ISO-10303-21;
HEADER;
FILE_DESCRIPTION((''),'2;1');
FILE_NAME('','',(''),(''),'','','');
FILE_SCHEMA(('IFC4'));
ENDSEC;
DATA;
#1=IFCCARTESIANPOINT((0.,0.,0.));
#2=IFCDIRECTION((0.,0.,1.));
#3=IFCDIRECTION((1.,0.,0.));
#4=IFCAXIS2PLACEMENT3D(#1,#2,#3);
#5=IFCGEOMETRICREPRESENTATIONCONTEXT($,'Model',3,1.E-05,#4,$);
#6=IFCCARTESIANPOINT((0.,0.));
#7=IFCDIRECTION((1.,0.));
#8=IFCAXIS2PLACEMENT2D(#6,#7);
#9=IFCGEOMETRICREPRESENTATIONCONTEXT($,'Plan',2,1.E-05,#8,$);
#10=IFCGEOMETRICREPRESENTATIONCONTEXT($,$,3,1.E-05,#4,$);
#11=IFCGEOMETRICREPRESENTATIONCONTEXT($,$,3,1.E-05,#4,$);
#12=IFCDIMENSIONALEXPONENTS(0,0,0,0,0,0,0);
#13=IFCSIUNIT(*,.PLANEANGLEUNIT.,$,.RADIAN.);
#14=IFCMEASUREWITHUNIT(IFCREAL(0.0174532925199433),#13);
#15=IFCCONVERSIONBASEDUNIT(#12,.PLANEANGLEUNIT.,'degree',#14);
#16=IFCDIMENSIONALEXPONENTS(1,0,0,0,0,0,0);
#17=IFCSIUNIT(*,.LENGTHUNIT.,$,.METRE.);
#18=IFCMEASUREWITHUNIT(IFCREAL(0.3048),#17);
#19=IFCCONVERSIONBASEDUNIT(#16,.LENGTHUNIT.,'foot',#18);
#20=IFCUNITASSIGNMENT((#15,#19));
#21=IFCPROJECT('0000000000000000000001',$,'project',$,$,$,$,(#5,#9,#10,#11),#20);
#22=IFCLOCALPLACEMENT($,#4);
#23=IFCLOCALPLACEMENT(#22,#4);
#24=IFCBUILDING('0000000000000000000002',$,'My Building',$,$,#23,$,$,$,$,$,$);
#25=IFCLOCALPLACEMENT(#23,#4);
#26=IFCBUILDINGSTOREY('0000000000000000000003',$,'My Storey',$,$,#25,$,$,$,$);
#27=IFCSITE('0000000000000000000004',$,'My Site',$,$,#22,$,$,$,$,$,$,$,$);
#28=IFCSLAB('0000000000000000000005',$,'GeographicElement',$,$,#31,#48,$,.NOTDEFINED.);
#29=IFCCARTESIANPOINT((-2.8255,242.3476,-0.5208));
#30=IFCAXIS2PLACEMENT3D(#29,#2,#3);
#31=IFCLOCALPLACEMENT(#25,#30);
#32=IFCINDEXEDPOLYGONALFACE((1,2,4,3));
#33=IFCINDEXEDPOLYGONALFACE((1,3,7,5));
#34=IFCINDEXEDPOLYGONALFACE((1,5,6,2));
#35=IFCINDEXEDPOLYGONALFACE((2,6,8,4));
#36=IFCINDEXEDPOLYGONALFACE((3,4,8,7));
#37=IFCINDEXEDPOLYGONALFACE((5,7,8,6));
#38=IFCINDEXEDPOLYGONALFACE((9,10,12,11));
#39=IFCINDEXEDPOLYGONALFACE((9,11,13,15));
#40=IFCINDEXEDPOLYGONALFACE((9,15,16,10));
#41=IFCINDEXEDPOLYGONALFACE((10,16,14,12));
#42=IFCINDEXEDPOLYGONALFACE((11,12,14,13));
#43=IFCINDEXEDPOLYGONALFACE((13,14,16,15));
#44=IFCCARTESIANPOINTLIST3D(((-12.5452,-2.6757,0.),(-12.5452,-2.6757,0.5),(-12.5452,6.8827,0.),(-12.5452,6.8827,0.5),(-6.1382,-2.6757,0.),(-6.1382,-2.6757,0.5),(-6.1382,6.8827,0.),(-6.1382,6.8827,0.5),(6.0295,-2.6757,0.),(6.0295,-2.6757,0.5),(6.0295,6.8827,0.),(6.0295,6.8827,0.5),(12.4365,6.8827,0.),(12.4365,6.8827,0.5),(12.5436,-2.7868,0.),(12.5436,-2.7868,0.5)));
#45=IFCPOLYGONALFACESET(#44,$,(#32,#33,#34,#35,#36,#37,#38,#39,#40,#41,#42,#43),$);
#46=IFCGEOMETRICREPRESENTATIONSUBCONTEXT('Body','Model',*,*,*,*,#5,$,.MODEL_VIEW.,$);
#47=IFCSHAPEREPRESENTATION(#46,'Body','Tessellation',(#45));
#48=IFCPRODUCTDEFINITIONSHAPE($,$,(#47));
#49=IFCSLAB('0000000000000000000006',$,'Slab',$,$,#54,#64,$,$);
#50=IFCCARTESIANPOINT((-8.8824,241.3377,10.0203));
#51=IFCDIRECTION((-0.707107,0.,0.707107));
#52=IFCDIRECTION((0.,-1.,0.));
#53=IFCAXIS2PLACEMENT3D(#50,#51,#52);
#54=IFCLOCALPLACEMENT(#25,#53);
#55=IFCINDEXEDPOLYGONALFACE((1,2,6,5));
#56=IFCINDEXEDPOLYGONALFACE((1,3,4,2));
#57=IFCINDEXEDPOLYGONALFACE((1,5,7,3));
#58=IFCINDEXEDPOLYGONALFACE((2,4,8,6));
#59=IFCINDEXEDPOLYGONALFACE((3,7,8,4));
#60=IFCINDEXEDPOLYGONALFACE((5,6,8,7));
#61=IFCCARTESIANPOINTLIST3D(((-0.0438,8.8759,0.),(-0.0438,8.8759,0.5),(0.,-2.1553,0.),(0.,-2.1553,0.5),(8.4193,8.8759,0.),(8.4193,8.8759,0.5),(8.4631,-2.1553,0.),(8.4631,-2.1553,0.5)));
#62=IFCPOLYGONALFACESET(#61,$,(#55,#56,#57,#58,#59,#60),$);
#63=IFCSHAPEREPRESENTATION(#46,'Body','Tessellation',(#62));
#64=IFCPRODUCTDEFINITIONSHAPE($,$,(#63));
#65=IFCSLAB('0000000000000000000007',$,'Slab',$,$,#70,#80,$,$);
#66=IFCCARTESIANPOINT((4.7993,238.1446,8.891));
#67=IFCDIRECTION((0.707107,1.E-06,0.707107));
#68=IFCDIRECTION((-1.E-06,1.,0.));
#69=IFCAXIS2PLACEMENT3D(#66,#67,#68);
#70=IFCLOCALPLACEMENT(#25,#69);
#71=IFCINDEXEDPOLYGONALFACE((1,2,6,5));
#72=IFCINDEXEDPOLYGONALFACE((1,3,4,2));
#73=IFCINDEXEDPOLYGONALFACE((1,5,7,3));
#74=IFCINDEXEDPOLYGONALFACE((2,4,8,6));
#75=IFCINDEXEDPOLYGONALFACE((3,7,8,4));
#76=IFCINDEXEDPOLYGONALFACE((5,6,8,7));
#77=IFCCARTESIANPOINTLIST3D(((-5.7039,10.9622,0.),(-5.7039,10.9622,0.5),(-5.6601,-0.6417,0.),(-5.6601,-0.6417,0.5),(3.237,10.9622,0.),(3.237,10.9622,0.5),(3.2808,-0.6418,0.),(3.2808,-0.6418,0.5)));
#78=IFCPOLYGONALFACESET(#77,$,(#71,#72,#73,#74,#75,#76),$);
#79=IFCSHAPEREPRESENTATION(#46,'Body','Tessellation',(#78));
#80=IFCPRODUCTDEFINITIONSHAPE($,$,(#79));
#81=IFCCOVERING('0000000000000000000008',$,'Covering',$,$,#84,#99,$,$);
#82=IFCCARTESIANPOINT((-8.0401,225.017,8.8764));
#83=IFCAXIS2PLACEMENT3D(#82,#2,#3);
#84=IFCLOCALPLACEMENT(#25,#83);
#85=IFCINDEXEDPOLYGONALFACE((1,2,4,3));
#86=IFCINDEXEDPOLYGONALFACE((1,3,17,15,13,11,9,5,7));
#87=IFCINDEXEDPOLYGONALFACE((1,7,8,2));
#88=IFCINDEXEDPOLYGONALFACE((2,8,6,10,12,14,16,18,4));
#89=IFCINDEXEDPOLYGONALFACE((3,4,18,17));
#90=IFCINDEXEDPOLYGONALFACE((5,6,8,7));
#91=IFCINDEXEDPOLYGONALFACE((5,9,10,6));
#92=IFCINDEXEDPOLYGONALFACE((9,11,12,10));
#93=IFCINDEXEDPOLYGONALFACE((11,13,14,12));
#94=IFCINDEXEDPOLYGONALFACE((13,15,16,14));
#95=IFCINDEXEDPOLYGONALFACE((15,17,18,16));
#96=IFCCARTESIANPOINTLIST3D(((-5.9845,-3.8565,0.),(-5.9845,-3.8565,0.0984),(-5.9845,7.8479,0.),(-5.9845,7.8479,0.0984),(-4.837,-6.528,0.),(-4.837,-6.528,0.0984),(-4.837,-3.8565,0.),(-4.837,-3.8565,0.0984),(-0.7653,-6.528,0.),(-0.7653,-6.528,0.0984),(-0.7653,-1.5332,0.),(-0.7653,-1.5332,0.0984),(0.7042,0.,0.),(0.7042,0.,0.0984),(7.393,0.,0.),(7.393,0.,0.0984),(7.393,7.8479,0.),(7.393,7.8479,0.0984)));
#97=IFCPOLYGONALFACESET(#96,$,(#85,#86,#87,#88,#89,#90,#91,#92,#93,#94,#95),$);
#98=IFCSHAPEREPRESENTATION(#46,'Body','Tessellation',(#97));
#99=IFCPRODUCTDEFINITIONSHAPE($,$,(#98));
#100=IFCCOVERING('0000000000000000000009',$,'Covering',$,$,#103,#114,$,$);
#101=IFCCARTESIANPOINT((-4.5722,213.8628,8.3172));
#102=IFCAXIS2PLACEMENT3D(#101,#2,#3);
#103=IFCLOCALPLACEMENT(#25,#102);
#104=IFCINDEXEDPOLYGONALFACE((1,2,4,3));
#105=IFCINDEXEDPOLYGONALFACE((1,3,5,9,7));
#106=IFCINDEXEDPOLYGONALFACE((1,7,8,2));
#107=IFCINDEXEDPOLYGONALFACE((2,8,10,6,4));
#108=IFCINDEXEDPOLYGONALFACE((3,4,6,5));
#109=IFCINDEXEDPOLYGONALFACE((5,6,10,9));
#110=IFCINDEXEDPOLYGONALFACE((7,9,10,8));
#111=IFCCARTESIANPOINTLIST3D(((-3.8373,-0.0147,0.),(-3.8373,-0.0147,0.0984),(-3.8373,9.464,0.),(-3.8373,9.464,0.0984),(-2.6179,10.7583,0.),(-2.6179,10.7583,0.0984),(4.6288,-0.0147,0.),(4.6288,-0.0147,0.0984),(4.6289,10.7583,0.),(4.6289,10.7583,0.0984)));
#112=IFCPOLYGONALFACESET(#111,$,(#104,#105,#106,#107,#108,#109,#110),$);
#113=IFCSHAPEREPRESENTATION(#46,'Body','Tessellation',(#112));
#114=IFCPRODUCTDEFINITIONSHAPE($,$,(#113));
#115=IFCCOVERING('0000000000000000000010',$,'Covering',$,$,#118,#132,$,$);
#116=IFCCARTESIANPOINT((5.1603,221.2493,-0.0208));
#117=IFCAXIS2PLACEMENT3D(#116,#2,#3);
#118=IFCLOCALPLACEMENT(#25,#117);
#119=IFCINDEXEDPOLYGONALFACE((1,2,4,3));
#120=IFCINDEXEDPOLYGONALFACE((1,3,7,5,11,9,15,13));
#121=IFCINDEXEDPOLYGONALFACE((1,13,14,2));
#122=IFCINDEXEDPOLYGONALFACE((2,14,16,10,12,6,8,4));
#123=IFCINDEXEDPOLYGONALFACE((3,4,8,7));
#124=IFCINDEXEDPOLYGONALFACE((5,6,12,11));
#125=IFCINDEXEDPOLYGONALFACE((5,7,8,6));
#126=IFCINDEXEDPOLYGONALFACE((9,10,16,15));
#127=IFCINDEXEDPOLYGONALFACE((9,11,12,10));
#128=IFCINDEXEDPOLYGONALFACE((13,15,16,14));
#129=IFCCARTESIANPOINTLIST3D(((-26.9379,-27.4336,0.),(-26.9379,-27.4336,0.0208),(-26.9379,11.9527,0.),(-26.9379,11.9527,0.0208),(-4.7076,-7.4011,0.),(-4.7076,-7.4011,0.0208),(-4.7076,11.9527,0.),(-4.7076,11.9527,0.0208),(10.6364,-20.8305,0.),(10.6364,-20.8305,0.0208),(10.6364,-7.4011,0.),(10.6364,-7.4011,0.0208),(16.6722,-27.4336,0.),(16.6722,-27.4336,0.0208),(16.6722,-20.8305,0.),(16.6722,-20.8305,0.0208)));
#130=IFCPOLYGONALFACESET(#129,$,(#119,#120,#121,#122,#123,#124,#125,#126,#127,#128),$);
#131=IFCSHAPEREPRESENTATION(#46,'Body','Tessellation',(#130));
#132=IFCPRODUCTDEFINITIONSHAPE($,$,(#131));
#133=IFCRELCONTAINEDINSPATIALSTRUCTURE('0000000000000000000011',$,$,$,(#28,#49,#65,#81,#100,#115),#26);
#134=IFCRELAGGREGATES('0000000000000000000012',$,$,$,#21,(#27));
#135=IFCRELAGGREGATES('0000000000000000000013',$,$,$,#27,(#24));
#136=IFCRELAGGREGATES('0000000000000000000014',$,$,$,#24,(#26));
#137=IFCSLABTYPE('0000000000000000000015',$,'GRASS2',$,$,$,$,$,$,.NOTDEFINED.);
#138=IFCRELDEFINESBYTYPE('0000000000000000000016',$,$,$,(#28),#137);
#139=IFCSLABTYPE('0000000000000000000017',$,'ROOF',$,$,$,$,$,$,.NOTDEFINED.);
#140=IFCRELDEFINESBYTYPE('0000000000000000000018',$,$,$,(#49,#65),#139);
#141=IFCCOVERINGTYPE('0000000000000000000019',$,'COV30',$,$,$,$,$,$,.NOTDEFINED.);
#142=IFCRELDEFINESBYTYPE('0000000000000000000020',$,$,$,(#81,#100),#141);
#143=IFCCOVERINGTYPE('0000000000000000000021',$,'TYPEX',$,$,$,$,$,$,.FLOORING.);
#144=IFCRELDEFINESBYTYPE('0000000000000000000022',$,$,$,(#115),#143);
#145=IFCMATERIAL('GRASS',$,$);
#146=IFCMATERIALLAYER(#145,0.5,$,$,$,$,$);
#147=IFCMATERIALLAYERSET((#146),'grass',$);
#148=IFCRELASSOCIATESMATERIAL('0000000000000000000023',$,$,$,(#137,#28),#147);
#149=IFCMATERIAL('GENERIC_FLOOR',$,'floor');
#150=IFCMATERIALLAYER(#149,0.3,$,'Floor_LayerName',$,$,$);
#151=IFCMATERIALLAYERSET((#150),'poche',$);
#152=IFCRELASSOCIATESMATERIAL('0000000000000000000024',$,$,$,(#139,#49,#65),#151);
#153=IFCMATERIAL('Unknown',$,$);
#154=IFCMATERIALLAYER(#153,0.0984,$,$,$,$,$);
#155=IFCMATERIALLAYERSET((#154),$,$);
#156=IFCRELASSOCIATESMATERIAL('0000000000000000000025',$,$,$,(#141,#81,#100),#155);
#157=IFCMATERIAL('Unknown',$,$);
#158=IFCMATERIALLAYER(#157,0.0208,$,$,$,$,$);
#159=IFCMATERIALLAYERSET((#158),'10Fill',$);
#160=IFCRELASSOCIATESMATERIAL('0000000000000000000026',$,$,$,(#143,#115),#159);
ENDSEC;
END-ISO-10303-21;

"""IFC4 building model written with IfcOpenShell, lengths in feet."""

from ifc_helpers import new_model, entity, si_unit, converted_unit, frame, origin_with_axes, origin_2d_with_axis, place, context, subcontext, project, spatial, line, indexed_curve, outline, extrude, material, layer, layer_set, layer_usage, type_object, element, save


model = new_model("IFC4")

# Units and contexts
model_context = context("Model", 3, precision=1e-05, world=origin_with_axes())
plan_context = context("Plan", 2, precision=1e-05, world=origin_2d_with_axis())
context_of_model_1 = context(None, 3, precision=1e-05, world=origin_with_axes())
context_of_model_2 = context(None, 3, precision=1e-05, world=origin_with_axes())
body_context_1 = subcontext(model_context, "Body", "Model", "MODEL_VIEW")
ifc_project = project(units=[converted_unit("PLANEANGLEUNIT", "degree", entity("IfcReal", 0.0174532925199433), si_unit("PLANEANGLEUNIT", "RADIAN"), dimensions=[0, 0, 0, 0, 0, 0, 0]), converted_unit("LENGTHUNIT", "foot", entity("IfcReal", 0.3048), si_unit("LENGTHUNIT", "METRE"), dimensions=[1, 0, 0, 0, 0, 0, 0])], contexts=[model_context, plan_context, context_of_model_1, context_of_model_2])

# Site, building, storey
site_placement = place(None, origin_with_axes())
site = spatial("IfcSite", under=ifc_project, at=site_placement, Name="My Site")
building_placement = place(site_placement, origin_with_axes())
building = spatial("IfcBuilding", under=site, at=building_placement, Name="My Building")
storey_placement = place(building_placement, origin_with_axes())
storey = spatial("IfcBuildingStorey", under=building, at=storey_placement, Name="My Storey")

# Slabs
ifc_material_1 = material(Name="GRASS")
ifc_layer_1 = layer(ifc_material_1, 0.5)
ifc_layer_set_1 = layer_set([ifc_layer_1], Name="grass")
ifc_layer_usage_1 = layer_usage(ifc_layer_set_1, "AXIS3", "POSITIVE", 0.0)
slab_type_1 = type_object("IfcSlabType", Name="GRASS2", PredefinedType="NOTDEFINED", material=ifc_layer_set_1)
slab_1_placement = place(storey_placement, frame((-2.8255, 242.3476, -0.5208), z_axis=(0.0, 0.0, 1.0), x_axis=(1.0, 0.0, 0.0)))
element("IfcSlab", 1, at=slab_1_placement, inside=storey, type_object=slab_type_1, material=ifc_layer_usage_1, Name="GeographicElement", PredefinedType="NOTDEFINED", context=body_context_1, shape_type="SweptSolid", body=[
    extrude(outline(indexed_curve([(-12.5452, -2.6757), (-6.1382, -2.6757), (-6.1382, 6.8827), (-12.5452, 6.8827), (6.0295, -2.6757), (6.0295, 6.8827), (12.4365, 6.8827), (12.5436, -2.7868)], segments=[line(7, 6), line(6, 5), line(5, 8), line(8, 7)], self_intersect=False), holes=[indexed_curve([(-12.5452, -2.6757), (-6.1382, -2.6757), (-6.1382, 6.8827), (-12.5452, 6.8827), (6.0295, -2.6757), (6.0295, 6.8827), (12.4365, 6.8827), (12.5436, -2.7868)], segments=[line(3, 4), line(4, 1), line(1, 2), line(2, 3)], self_intersect=False)]), None, (0.0, 0.0, 1.0), 0.5),
])
ifc_material_2 = material(Name="GENERIC_FLOOR", Category="floor")
ifc_layer_2 = layer(ifc_material_2, 0.3, Name="Floor_LayerName")
ifc_layer_set_2 = layer_set([ifc_layer_2], Name="poche")
ifc_layer_usage_2 = layer_usage(ifc_layer_set_2, "AXIS3", "POSITIVE", 0.0)
slab_type_2 = type_object("IfcSlabType", Name="ROOF", PredefinedType="NOTDEFINED", material=ifc_layer_set_2)
slab_2_placement = place(storey_placement, frame((-8.8824, 241.3377, 10.0203), z_axis=(-0.707107, 0.0, 0.707107), x_axis=(0.0, -1.0, 0.0)))
element("IfcSlab", 2, at=slab_2_placement, inside=storey, type_object=slab_type_2, material=ifc_layer_usage_2, Name="Slab", context=body_context_1, shape_type="SweptSolid", body=[
    extrude(outline(indexed_curve([(0.0, -2.1553), (8.4631, -2.1553), (8.4193, 8.8759), (-0.0438, 8.8759)], segments=[line(3, 2), line(2, 1), line(1, 4), line(4, 3)], self_intersect=False)), None, (0.0, 0.0, 1.0), 0.5),
])
ifc_layer_usage_3 = layer_usage(ifc_layer_set_2, "AXIS3", "POSITIVE", 0.0)
slab_3_placement = place(storey_placement, frame((4.7993, 238.1446, 8.891), z_axis=(0.707107, 0.000001, 0.707107), x_axis=(-0.000001, 1.0, 0.0)))
element("IfcSlab", 3, at=slab_3_placement, inside=storey, type_object=slab_type_2, material=ifc_layer_usage_3, Name="Slab", context=body_context_1, shape_type="SweptSolid", body=[
    extrude(outline(indexed_curve([(3.237, 10.9622), (3.2808, -0.6418), (-5.6601, -0.6417), (-5.7039, 10.9622)], segments=[line(3, 2), line(2, 1), line(1, 4), line(4, 3)], self_intersect=False)), None, (0.0, 0.0, 1.0), 0.5),
])

# Coverings
ifc_material_3 = material(Name="Unknown")
ifc_layer_3 = layer(ifc_material_3, 0.0984)
ifc_layer_set_3 = layer_set([ifc_layer_3])
ifc_layer_usage_4 = layer_usage(ifc_layer_set_3, "AXIS3", "POSITIVE", 0.0)
covering_type_1 = type_object("IfcCoveringType", Name="COV30", PredefinedType="NOTDEFINED", material=ifc_layer_set_3)
covering_1_placement = place(storey_placement, frame((-8.0401, 225.017, 8.8764), z_axis=(0.0, 0.0, 1.0), x_axis=(1.0, 0.0, 0.0)))
element("IfcCovering", 4, at=covering_1_placement, inside=storey, type_object=covering_type_1, material=ifc_layer_usage_4, Name="Covering", context=body_context_1, shape_type="SweptSolid", body=[
    extrude(outline(indexed_curve([(-5.9845, -3.8565), (-5.9845, 7.8479), (7.393, 7.8479), (7.393, 0.0), (0.7042, 0.0), (-0.7653, -1.5332), (-0.7653, -6.528), (-4.837, -6.528), (-4.837, -3.8565)], segments=[line(3, 2), line(2, 1), line(1, 9), line(9, 8), line(8, 7), line(7, 6), line(6, 5), line(5, 4), line(4, 3)], self_intersect=False)), None, (0.0, 0.0, 1.0), 0.0984),
])
ifc_layer_usage_5 = layer_usage(ifc_layer_set_3, "AXIS3", "POSITIVE", 0.0)
covering_2_placement = place(storey_placement, frame((-4.5722, 213.8628, 8.3172), z_axis=(0.0, 0.0, 1.0), x_axis=(1.0, 0.0, 0.0)))
element("IfcCovering", 5, at=covering_2_placement, inside=storey, type_object=covering_type_1, material=ifc_layer_usage_5, Name="Covering", context=body_context_1, shape_type="SweptSolid", body=[
    extrude(outline(indexed_curve([(-3.8373, 9.464), (-3.8373, -0.0147), (4.6288, -0.0147), (4.6289, 10.7583), (-2.6179, 10.7583)], segments=[line(4, 5), line(5, 1), line(1, 2), line(2, 3), line(3, 4)], self_intersect=False)), None, (0.0, 0.0, 1.0), 0.0984),
])
ifc_material_4 = material(Name="Unknown")
ifc_layer_4 = layer(ifc_material_4, 0.0208)
ifc_layer_set_4 = layer_set([ifc_layer_4], Name="10Fill")
ifc_layer_usage_6 = layer_usage(ifc_layer_set_4, "AXIS3", "POSITIVE", 0.0)
covering_type_2 = type_object("IfcCoveringType", Name="TYPEX", PredefinedType="FLOORING", material=ifc_layer_set_4)
covering_3_placement = place(storey_placement, frame((5.1603, 221.2493, -0.0208), z_axis=(0.0, 0.0, 1.0), x_axis=(1.0, 0.0, 0.0)))
element("IfcCovering", 6, at=covering_3_placement, inside=storey, type_object=covering_type_2, material=ifc_layer_usage_6, Name="Covering", context=body_context_1, shape_type="SweptSolid", body=[
    extrude(outline(indexed_curve([(-26.9379, 11.9527), (-26.9379, -27.4336), (16.6722, -27.4336), (16.6722, -20.8305), (10.6364, -20.8305), (10.6364, -7.4011), (-4.7076, -7.4011), (-4.7076, 11.9527)], segments=[line(1, 8), line(8, 7), line(7, 6), line(6, 5), line(5, 4), line(4, 3), line(3, 2), line(2, 1)], self_intersect=False)), None, (0.0, 0.0, 1.0), 0.0208),
])

save(model, "model.ifc")
